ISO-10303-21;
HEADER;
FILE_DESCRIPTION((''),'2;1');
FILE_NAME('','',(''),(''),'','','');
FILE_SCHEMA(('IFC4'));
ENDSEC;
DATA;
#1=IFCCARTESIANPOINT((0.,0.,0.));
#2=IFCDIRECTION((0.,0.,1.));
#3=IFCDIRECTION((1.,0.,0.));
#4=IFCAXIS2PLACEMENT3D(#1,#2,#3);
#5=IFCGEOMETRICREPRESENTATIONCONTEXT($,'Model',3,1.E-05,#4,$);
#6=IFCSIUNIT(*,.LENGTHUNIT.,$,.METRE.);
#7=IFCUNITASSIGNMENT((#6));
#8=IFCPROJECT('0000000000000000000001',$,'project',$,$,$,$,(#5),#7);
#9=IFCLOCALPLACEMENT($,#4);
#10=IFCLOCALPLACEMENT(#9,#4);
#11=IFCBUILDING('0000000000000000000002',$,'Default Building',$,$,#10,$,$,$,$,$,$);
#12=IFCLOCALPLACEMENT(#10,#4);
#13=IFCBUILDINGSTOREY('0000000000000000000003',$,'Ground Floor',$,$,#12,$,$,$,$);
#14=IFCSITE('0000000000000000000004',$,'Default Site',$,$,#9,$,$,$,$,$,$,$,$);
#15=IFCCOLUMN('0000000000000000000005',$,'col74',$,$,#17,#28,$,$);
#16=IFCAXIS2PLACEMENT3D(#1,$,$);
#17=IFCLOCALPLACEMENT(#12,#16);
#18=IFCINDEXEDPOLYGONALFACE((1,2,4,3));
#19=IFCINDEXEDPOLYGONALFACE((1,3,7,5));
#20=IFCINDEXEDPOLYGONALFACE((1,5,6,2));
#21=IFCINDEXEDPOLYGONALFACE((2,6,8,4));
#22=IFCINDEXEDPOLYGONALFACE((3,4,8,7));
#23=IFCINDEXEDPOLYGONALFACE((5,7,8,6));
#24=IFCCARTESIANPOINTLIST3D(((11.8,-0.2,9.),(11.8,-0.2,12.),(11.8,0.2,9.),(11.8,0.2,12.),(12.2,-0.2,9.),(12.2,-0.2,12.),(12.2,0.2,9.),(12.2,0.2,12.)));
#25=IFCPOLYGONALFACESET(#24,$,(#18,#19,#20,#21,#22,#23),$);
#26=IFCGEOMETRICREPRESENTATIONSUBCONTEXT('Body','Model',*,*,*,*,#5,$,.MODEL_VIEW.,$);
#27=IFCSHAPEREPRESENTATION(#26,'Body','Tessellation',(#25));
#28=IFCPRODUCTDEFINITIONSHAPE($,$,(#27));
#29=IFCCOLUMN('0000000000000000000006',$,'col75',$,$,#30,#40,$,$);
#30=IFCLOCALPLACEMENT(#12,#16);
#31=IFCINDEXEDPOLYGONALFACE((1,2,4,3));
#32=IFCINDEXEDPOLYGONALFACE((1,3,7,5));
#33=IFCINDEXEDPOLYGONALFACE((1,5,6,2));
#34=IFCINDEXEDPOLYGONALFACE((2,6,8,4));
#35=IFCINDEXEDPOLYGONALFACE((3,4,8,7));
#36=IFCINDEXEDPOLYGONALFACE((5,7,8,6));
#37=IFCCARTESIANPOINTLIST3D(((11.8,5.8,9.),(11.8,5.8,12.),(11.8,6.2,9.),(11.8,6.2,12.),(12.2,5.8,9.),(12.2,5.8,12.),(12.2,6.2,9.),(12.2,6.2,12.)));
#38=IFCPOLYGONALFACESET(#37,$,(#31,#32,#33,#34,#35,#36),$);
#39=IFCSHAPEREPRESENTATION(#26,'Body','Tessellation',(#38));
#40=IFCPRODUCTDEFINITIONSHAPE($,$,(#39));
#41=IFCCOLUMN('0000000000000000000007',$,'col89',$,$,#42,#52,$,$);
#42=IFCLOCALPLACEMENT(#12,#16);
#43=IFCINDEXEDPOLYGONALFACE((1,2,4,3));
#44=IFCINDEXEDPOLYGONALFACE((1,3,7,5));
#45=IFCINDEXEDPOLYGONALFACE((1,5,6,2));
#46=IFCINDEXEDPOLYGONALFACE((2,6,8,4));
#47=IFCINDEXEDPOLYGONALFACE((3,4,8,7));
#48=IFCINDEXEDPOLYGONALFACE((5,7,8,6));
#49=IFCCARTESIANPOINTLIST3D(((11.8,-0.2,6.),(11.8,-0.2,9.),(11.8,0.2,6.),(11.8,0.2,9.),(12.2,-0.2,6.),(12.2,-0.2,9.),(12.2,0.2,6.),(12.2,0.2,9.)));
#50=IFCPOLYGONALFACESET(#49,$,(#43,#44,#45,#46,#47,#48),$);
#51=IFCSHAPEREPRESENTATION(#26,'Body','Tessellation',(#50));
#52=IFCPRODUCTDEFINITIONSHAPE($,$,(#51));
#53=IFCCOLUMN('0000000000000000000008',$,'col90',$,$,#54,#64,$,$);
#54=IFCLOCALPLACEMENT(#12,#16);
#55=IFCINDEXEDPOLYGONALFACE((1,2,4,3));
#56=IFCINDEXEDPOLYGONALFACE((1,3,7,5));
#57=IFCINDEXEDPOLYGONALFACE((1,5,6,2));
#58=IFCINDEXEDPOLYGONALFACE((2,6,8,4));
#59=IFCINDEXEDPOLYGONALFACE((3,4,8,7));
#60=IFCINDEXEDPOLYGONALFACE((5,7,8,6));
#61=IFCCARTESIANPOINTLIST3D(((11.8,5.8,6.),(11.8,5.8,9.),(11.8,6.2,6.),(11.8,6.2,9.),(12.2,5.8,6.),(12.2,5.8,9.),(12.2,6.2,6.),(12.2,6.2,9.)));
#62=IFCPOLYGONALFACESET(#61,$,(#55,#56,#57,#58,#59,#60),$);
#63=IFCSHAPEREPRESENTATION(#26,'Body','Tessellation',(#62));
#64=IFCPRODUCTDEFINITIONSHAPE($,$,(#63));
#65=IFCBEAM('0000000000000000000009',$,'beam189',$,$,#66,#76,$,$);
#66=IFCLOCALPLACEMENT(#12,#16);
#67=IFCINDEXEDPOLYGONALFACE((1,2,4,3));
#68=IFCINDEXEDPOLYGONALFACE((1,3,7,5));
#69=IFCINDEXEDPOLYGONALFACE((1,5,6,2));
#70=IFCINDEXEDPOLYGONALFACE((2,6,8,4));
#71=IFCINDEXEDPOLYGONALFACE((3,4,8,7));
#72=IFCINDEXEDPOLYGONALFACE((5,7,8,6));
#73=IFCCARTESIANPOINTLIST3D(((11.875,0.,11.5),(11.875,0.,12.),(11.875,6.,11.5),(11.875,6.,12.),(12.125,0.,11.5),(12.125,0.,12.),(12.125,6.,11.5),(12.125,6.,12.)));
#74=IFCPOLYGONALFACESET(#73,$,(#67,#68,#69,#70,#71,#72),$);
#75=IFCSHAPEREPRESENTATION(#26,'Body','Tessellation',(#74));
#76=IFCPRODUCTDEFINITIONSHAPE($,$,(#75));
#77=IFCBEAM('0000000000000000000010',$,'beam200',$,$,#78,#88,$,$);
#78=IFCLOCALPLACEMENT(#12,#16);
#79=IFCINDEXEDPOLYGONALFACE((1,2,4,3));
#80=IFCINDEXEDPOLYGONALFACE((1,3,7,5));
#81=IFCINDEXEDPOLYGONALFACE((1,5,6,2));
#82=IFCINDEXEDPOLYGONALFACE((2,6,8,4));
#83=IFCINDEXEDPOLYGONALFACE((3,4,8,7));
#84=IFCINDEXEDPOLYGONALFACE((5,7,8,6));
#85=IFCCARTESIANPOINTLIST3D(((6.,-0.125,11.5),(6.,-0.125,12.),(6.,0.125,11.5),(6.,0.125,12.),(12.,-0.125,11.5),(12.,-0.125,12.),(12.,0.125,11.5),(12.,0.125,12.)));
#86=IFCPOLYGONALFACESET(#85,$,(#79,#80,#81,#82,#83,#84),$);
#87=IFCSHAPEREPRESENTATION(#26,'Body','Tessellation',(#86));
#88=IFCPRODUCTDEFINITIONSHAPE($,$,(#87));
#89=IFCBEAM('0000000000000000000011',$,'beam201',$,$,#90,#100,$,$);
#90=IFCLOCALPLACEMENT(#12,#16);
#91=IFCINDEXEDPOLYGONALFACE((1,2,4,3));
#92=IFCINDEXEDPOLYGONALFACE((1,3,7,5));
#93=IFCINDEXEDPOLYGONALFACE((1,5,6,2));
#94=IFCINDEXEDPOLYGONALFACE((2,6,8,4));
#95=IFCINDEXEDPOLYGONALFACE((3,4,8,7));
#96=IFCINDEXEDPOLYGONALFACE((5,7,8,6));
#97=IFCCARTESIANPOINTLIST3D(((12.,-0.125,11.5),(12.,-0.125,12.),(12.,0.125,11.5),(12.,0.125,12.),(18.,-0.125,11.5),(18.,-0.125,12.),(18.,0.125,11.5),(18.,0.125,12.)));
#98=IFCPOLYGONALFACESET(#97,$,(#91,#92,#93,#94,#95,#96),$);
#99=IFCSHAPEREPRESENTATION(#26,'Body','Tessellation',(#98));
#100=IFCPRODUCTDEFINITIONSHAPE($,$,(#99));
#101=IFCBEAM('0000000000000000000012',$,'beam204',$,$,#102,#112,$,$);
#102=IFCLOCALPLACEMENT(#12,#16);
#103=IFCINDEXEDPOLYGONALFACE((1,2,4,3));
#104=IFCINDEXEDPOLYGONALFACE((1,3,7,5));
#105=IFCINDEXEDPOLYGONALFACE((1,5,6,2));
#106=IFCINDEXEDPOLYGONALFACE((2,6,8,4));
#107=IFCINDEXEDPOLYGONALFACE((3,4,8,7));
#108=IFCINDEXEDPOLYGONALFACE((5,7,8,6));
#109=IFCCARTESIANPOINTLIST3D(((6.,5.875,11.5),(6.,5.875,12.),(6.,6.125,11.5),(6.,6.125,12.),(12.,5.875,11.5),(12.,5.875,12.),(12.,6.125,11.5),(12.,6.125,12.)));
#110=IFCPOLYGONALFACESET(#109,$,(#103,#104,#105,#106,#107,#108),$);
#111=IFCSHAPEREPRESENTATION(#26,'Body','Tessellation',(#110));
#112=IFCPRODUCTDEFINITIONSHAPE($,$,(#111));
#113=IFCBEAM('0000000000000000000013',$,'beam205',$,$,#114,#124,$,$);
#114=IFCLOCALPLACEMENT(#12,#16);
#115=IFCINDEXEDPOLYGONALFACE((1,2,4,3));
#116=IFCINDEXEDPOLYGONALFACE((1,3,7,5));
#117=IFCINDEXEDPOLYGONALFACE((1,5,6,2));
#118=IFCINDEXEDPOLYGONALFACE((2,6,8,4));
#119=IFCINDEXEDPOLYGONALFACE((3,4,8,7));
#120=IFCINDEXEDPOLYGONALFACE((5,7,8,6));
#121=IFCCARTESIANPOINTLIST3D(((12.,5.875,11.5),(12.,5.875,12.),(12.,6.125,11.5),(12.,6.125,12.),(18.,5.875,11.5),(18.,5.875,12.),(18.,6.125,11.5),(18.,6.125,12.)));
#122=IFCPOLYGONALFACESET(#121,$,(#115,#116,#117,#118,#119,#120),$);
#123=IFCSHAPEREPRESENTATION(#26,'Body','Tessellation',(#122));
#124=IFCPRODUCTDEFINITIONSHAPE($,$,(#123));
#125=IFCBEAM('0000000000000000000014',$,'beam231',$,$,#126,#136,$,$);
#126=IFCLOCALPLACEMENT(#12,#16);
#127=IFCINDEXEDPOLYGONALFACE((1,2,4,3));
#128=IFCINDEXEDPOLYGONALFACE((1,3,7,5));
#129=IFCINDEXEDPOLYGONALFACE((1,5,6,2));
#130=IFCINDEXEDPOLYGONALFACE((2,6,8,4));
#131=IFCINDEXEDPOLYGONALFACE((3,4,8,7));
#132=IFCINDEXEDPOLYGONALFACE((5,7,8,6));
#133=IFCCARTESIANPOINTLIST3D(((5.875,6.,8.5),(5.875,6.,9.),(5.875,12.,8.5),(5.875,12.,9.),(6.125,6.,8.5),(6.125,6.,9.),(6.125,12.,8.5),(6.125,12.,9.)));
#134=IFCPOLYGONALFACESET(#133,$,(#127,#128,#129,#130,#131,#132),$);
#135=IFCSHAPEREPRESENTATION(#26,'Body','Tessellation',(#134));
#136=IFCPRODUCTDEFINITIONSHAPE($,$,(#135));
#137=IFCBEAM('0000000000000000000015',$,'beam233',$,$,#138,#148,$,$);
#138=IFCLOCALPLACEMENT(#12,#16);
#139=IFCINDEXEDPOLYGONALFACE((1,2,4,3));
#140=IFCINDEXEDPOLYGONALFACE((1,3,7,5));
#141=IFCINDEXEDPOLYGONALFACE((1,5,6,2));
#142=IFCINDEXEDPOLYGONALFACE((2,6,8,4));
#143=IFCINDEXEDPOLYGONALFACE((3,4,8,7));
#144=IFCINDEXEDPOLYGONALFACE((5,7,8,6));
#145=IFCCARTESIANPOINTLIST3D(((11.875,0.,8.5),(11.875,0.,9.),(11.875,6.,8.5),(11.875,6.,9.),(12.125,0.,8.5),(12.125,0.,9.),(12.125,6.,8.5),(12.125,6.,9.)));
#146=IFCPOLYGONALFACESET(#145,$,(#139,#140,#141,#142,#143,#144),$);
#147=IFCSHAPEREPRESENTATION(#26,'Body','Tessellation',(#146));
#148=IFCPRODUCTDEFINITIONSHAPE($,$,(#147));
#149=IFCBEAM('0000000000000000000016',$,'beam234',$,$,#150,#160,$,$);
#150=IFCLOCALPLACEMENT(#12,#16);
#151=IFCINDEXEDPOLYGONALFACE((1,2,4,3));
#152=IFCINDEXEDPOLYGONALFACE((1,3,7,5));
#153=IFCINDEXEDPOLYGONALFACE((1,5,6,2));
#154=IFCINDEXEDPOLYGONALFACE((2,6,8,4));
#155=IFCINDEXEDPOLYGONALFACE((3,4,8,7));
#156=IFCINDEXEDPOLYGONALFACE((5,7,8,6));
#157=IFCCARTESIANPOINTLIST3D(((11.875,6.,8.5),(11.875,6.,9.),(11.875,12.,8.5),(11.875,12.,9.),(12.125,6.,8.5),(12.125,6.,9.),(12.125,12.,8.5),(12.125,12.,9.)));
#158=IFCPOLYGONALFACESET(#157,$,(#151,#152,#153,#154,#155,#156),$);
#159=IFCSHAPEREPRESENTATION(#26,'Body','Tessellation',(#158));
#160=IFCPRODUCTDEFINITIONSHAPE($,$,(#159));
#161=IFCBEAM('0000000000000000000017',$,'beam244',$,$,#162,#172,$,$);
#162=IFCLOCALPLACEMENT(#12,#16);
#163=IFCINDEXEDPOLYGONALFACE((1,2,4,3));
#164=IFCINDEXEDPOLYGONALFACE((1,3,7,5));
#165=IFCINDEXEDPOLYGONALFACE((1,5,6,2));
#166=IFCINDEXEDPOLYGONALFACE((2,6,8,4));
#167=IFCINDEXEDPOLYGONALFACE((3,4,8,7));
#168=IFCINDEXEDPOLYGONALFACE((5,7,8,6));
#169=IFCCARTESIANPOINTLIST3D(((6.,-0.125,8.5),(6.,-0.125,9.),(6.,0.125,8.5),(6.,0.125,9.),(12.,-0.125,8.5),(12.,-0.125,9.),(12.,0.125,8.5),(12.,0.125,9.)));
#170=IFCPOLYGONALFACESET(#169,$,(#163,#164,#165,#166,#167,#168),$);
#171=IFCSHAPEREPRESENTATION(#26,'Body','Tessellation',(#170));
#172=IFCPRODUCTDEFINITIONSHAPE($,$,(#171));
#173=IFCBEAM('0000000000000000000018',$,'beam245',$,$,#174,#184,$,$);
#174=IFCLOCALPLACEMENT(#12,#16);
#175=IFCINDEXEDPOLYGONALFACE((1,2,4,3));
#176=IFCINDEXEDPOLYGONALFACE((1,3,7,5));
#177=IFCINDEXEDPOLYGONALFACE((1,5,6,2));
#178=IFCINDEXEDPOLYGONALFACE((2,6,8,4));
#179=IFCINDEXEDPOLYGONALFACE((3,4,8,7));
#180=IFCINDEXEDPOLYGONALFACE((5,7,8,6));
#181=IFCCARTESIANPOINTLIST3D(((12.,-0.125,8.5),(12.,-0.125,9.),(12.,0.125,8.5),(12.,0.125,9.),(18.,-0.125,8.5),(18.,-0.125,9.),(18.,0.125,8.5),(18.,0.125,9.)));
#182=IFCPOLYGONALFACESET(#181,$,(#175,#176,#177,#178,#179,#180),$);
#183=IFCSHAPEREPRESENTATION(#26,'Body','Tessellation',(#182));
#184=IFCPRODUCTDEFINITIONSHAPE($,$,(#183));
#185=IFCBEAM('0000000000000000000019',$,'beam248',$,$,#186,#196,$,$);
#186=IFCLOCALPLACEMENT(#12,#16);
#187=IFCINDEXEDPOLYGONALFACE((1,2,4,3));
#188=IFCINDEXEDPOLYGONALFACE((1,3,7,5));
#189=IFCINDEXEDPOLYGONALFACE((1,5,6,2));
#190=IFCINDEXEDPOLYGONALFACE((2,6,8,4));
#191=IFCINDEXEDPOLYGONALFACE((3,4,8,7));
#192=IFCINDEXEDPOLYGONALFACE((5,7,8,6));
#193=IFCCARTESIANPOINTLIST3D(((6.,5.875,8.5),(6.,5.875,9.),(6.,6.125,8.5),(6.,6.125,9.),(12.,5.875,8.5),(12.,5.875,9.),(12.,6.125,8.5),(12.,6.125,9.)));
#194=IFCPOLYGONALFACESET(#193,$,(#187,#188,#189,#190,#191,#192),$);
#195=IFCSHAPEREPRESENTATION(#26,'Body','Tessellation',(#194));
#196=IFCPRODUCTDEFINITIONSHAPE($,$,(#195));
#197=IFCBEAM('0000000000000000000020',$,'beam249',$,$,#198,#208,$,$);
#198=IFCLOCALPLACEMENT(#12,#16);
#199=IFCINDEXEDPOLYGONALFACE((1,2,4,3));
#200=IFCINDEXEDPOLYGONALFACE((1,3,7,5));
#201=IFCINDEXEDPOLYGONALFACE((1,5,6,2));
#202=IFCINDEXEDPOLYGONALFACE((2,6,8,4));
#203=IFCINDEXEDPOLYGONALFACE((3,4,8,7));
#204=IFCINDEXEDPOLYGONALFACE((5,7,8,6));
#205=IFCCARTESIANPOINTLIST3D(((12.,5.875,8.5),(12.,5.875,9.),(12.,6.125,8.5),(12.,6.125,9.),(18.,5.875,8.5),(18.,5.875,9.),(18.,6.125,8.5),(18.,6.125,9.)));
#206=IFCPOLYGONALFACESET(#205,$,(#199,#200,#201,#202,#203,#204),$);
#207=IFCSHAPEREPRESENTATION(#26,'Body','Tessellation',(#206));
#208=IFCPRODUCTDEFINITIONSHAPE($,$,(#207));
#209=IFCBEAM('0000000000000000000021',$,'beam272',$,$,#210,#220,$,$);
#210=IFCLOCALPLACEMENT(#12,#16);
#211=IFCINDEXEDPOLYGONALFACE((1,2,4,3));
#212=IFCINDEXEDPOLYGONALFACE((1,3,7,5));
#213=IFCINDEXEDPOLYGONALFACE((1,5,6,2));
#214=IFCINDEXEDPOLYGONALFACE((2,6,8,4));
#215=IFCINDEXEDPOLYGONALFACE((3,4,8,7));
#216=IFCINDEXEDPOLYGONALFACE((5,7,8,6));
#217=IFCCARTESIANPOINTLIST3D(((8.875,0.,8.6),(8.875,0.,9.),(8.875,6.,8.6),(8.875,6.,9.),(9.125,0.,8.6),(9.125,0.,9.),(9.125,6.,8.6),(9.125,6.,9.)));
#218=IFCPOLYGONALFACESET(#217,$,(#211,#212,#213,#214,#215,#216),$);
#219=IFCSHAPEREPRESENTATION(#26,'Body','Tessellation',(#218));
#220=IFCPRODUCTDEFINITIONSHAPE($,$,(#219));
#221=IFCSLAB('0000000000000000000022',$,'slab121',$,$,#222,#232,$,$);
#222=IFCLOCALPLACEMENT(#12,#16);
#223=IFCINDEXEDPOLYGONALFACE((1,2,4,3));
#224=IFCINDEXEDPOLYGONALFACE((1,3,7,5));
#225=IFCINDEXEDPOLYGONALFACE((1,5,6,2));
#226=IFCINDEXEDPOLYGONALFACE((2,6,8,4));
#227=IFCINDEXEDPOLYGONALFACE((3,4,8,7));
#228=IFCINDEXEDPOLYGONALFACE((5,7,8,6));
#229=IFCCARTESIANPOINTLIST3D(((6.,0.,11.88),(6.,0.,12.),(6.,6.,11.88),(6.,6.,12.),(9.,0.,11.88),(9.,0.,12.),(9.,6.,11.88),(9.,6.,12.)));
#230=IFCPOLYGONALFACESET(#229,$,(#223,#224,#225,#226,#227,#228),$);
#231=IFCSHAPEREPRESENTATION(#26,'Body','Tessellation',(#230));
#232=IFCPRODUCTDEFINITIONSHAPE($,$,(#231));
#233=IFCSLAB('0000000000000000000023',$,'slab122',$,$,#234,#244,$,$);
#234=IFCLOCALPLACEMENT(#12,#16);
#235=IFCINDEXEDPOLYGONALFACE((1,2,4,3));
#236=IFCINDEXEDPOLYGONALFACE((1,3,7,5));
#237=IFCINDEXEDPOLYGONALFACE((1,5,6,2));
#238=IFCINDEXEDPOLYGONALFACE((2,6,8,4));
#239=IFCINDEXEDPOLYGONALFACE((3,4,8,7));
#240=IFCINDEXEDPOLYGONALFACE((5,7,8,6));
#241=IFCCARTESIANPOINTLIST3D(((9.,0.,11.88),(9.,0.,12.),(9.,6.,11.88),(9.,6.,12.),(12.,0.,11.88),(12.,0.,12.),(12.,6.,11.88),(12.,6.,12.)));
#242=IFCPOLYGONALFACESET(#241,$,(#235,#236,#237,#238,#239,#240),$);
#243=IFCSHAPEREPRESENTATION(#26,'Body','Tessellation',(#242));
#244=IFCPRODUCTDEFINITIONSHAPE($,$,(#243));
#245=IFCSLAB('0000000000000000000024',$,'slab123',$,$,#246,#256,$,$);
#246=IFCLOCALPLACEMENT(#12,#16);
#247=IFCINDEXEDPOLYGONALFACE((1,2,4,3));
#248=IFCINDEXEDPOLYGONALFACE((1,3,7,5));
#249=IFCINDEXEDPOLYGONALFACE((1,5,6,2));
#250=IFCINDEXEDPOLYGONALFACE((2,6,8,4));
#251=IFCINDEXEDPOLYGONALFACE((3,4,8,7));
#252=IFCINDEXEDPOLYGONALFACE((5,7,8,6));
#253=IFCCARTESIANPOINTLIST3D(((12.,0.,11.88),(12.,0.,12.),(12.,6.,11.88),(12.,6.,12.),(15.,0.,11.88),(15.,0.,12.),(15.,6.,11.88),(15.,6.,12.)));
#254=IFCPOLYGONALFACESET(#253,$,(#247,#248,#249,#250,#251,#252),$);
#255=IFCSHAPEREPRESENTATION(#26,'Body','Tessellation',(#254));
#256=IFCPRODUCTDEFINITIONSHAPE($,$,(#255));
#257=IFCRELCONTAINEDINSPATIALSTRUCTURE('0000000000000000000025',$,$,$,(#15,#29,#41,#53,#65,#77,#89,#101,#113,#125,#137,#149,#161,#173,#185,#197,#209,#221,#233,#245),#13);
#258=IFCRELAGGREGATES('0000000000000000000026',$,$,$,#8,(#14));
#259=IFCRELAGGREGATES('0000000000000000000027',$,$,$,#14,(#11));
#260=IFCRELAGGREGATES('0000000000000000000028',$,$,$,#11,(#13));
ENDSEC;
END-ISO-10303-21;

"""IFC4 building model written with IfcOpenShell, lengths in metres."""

from ifc_helpers import new_model, si_unit, frame, origin_with_axes, place, context, subcontext, project, spatial, indexed_curve, outline, extrude, element, save


model = new_model("IFC4")

# Units and contexts
model_context = context("Model", 3, precision=1e-05, world=origin_with_axes())
body_context = subcontext(model_context, "Body", "Model", "MODEL_VIEW")
ifc_project = project(units=[si_unit("LENGTHUNIT", "METRE")], contexts=[model_context])

# Site, building, storey
site_placement = place(None, origin_with_axes())
site = spatial("IfcSite", under=ifc_project, at=site_placement, Name="Default Site")
building_placement = place(site_placement, origin_with_axes())
building = spatial("IfcBuilding", under=site, at=building_placement, Name="Default Building")
storey_placement = place(building_placement, origin_with_axes())
storey = spatial("IfcBuildingStorey", under=building, at=storey_placement, Name="Ground Floor")

# Columns
for number, where, z_axis, x_axis, name in (
    (1, (11.8, -0.2, 9.0), (0.0, 0.0, 1.0), (1.0, 0.0, 0.0), "col74"),
    (2, (11.8, 5.8, 9.0), (0.0, 0.0, 1.0), (1.0, 0.0, 0.0), "col75"),
    (3, (11.8, -0.2, 6.0), (0.0, 0.0, 1.0), (1.0, 0.0, 0.0), "col89"),
    (4, (11.8, 5.8, 6.0), (0.0, 0.0, 1.0), (1.0, 0.0, 0.0), "col90"),
):
    element("IfcColumn", number, at=place(storey_placement, frame(where, z_axis=z_axis, x_axis=x_axis)), inside=storey, Name=name, context=body_context, shape_type="SweptSolid", body=[
        extrude(outline(indexed_curve([(0.0, 0.0), (0.0, 0.4), (0.4, 0.4), (0.4, 0.0), (0.0, 0.0)], self_intersect=False)), origin_with_axes(), (0.0, 0.0, 1.0), 3.0),
    ])

# Beams
for number, where, z_axis, x_axis, name in (
    (5, (12.125, 0.0, 11.5), (0.0, 0.0, 1.0), (0.0, 1.0, 0.0), "beam189"),
    (6, (6.0, -0.125, 11.5), (0.0, 0.0, 1.0), (1.0, 0.0, 0.0), "beam200"),
    (7, (12.0, -0.125, 11.5), (0.0, 0.0, 1.0), (1.0, 0.0, 0.0), "beam201"),
    (8, (6.0, 5.875, 11.5), (0.0, 0.0, 1.0), (1.0, 0.0, 0.0), "beam204"),
    (9, (12.0, 5.875, 11.5), (0.0, 0.0, 1.0), (1.0, 0.0, 0.0), "beam205"),
    (10, (6.125, 6.0, 8.5), (0.0, 0.0, 1.0), (0.0, 1.0, 0.0), "beam231"),
    (11, (12.125, 0.0, 8.5), (0.0, 0.0, 1.0), (0.0, 1.0, 0.0), "beam233"),
    (12, (12.125, 6.0, 8.5), (0.0, 0.0, 1.0), (0.0, 1.0, 0.0), "beam234"),
    (13, (6.0, -0.125, 8.5), (0.0, 0.0, 1.0), (1.0, 0.0, 0.0), "beam244"),
    (14, (12.0, -0.125, 8.5), (0.0, 0.0, 1.0), (1.0, 0.0, 0.0), "beam245"),
    (15, (6.0, 5.875, 8.5), (0.0, 0.0, 1.0), (1.0, 0.0, 0.0), "beam248"),
    (16, (12.0, 5.875, 8.5), (0.0, 0.0, 1.0), (1.0, 0.0, 0.0), "beam249"),
):
    element("IfcBeam", number, at=place(storey_placement, frame(where, z_axis=z_axis, x_axis=x_axis)), inside=storey, Name=name, context=body_context, shape_type="SweptSolid", body=[
        extrude(outline(indexed_curve([(0.0, 0.0), (0.0, 0.25), (6.0, 0.25), (6.0, 0.0), (0.0, 0.0)], self_intersect=False)), origin_with_axes(), (0.0, 0.0, 1.0), 0.5),
    ])
beam_placement = place(storey_placement, frame((8.875, 6.0, 8.6), z_axis=(0.0, 0.0, 1.0), x_axis=(0.0, -1.0, 0.0)))
element("IfcBeam", 17, at=beam_placement, inside=storey, Name="beam272", context=body_context, shape_type="SweptSolid", body=[
    extrude(outline(indexed_curve([(0.0, 0.0), (0.0, 0.25), (6.0, 0.25), (6.0, 0.0), (0.0, 0.0)], self_intersect=False)), origin_with_axes(), (0.0, 0.0, 1.0), 0.4),
])

# Slabs
for number, where, z_axis, x_axis, name in (
    (18, (6.0, 0.0, 11.88), (0.0, 0.0, 1.0), (1.0, 0.0, 0.0), "slab121"),
    (19, (9.0, 0.0, 11.88), (0.0, 0.0, 1.0), (1.0, 0.0, 0.0), "slab122"),
    (20, (12.0, 0.0, 11.88), (0.0, 0.0, 1.0), (1.0, 0.0, 0.0), "slab123"),
):
    element("IfcSlab", number, at=place(storey_placement, frame(where, z_axis=z_axis, x_axis=x_axis)), inside=storey, Name=name, context=body_context, shape_type="SweptSolid", body=[
        extrude(outline(indexed_curve([(0.0, 0.0), (0.0, 6.0), (3.0, 6.0), (3.0, 0.0), (0.0, 0.0)], self_intersect=False)), origin_with_axes(), (0.0, 0.0, 1.0), 0.12),
    ])

save(model, "model.ifc")
